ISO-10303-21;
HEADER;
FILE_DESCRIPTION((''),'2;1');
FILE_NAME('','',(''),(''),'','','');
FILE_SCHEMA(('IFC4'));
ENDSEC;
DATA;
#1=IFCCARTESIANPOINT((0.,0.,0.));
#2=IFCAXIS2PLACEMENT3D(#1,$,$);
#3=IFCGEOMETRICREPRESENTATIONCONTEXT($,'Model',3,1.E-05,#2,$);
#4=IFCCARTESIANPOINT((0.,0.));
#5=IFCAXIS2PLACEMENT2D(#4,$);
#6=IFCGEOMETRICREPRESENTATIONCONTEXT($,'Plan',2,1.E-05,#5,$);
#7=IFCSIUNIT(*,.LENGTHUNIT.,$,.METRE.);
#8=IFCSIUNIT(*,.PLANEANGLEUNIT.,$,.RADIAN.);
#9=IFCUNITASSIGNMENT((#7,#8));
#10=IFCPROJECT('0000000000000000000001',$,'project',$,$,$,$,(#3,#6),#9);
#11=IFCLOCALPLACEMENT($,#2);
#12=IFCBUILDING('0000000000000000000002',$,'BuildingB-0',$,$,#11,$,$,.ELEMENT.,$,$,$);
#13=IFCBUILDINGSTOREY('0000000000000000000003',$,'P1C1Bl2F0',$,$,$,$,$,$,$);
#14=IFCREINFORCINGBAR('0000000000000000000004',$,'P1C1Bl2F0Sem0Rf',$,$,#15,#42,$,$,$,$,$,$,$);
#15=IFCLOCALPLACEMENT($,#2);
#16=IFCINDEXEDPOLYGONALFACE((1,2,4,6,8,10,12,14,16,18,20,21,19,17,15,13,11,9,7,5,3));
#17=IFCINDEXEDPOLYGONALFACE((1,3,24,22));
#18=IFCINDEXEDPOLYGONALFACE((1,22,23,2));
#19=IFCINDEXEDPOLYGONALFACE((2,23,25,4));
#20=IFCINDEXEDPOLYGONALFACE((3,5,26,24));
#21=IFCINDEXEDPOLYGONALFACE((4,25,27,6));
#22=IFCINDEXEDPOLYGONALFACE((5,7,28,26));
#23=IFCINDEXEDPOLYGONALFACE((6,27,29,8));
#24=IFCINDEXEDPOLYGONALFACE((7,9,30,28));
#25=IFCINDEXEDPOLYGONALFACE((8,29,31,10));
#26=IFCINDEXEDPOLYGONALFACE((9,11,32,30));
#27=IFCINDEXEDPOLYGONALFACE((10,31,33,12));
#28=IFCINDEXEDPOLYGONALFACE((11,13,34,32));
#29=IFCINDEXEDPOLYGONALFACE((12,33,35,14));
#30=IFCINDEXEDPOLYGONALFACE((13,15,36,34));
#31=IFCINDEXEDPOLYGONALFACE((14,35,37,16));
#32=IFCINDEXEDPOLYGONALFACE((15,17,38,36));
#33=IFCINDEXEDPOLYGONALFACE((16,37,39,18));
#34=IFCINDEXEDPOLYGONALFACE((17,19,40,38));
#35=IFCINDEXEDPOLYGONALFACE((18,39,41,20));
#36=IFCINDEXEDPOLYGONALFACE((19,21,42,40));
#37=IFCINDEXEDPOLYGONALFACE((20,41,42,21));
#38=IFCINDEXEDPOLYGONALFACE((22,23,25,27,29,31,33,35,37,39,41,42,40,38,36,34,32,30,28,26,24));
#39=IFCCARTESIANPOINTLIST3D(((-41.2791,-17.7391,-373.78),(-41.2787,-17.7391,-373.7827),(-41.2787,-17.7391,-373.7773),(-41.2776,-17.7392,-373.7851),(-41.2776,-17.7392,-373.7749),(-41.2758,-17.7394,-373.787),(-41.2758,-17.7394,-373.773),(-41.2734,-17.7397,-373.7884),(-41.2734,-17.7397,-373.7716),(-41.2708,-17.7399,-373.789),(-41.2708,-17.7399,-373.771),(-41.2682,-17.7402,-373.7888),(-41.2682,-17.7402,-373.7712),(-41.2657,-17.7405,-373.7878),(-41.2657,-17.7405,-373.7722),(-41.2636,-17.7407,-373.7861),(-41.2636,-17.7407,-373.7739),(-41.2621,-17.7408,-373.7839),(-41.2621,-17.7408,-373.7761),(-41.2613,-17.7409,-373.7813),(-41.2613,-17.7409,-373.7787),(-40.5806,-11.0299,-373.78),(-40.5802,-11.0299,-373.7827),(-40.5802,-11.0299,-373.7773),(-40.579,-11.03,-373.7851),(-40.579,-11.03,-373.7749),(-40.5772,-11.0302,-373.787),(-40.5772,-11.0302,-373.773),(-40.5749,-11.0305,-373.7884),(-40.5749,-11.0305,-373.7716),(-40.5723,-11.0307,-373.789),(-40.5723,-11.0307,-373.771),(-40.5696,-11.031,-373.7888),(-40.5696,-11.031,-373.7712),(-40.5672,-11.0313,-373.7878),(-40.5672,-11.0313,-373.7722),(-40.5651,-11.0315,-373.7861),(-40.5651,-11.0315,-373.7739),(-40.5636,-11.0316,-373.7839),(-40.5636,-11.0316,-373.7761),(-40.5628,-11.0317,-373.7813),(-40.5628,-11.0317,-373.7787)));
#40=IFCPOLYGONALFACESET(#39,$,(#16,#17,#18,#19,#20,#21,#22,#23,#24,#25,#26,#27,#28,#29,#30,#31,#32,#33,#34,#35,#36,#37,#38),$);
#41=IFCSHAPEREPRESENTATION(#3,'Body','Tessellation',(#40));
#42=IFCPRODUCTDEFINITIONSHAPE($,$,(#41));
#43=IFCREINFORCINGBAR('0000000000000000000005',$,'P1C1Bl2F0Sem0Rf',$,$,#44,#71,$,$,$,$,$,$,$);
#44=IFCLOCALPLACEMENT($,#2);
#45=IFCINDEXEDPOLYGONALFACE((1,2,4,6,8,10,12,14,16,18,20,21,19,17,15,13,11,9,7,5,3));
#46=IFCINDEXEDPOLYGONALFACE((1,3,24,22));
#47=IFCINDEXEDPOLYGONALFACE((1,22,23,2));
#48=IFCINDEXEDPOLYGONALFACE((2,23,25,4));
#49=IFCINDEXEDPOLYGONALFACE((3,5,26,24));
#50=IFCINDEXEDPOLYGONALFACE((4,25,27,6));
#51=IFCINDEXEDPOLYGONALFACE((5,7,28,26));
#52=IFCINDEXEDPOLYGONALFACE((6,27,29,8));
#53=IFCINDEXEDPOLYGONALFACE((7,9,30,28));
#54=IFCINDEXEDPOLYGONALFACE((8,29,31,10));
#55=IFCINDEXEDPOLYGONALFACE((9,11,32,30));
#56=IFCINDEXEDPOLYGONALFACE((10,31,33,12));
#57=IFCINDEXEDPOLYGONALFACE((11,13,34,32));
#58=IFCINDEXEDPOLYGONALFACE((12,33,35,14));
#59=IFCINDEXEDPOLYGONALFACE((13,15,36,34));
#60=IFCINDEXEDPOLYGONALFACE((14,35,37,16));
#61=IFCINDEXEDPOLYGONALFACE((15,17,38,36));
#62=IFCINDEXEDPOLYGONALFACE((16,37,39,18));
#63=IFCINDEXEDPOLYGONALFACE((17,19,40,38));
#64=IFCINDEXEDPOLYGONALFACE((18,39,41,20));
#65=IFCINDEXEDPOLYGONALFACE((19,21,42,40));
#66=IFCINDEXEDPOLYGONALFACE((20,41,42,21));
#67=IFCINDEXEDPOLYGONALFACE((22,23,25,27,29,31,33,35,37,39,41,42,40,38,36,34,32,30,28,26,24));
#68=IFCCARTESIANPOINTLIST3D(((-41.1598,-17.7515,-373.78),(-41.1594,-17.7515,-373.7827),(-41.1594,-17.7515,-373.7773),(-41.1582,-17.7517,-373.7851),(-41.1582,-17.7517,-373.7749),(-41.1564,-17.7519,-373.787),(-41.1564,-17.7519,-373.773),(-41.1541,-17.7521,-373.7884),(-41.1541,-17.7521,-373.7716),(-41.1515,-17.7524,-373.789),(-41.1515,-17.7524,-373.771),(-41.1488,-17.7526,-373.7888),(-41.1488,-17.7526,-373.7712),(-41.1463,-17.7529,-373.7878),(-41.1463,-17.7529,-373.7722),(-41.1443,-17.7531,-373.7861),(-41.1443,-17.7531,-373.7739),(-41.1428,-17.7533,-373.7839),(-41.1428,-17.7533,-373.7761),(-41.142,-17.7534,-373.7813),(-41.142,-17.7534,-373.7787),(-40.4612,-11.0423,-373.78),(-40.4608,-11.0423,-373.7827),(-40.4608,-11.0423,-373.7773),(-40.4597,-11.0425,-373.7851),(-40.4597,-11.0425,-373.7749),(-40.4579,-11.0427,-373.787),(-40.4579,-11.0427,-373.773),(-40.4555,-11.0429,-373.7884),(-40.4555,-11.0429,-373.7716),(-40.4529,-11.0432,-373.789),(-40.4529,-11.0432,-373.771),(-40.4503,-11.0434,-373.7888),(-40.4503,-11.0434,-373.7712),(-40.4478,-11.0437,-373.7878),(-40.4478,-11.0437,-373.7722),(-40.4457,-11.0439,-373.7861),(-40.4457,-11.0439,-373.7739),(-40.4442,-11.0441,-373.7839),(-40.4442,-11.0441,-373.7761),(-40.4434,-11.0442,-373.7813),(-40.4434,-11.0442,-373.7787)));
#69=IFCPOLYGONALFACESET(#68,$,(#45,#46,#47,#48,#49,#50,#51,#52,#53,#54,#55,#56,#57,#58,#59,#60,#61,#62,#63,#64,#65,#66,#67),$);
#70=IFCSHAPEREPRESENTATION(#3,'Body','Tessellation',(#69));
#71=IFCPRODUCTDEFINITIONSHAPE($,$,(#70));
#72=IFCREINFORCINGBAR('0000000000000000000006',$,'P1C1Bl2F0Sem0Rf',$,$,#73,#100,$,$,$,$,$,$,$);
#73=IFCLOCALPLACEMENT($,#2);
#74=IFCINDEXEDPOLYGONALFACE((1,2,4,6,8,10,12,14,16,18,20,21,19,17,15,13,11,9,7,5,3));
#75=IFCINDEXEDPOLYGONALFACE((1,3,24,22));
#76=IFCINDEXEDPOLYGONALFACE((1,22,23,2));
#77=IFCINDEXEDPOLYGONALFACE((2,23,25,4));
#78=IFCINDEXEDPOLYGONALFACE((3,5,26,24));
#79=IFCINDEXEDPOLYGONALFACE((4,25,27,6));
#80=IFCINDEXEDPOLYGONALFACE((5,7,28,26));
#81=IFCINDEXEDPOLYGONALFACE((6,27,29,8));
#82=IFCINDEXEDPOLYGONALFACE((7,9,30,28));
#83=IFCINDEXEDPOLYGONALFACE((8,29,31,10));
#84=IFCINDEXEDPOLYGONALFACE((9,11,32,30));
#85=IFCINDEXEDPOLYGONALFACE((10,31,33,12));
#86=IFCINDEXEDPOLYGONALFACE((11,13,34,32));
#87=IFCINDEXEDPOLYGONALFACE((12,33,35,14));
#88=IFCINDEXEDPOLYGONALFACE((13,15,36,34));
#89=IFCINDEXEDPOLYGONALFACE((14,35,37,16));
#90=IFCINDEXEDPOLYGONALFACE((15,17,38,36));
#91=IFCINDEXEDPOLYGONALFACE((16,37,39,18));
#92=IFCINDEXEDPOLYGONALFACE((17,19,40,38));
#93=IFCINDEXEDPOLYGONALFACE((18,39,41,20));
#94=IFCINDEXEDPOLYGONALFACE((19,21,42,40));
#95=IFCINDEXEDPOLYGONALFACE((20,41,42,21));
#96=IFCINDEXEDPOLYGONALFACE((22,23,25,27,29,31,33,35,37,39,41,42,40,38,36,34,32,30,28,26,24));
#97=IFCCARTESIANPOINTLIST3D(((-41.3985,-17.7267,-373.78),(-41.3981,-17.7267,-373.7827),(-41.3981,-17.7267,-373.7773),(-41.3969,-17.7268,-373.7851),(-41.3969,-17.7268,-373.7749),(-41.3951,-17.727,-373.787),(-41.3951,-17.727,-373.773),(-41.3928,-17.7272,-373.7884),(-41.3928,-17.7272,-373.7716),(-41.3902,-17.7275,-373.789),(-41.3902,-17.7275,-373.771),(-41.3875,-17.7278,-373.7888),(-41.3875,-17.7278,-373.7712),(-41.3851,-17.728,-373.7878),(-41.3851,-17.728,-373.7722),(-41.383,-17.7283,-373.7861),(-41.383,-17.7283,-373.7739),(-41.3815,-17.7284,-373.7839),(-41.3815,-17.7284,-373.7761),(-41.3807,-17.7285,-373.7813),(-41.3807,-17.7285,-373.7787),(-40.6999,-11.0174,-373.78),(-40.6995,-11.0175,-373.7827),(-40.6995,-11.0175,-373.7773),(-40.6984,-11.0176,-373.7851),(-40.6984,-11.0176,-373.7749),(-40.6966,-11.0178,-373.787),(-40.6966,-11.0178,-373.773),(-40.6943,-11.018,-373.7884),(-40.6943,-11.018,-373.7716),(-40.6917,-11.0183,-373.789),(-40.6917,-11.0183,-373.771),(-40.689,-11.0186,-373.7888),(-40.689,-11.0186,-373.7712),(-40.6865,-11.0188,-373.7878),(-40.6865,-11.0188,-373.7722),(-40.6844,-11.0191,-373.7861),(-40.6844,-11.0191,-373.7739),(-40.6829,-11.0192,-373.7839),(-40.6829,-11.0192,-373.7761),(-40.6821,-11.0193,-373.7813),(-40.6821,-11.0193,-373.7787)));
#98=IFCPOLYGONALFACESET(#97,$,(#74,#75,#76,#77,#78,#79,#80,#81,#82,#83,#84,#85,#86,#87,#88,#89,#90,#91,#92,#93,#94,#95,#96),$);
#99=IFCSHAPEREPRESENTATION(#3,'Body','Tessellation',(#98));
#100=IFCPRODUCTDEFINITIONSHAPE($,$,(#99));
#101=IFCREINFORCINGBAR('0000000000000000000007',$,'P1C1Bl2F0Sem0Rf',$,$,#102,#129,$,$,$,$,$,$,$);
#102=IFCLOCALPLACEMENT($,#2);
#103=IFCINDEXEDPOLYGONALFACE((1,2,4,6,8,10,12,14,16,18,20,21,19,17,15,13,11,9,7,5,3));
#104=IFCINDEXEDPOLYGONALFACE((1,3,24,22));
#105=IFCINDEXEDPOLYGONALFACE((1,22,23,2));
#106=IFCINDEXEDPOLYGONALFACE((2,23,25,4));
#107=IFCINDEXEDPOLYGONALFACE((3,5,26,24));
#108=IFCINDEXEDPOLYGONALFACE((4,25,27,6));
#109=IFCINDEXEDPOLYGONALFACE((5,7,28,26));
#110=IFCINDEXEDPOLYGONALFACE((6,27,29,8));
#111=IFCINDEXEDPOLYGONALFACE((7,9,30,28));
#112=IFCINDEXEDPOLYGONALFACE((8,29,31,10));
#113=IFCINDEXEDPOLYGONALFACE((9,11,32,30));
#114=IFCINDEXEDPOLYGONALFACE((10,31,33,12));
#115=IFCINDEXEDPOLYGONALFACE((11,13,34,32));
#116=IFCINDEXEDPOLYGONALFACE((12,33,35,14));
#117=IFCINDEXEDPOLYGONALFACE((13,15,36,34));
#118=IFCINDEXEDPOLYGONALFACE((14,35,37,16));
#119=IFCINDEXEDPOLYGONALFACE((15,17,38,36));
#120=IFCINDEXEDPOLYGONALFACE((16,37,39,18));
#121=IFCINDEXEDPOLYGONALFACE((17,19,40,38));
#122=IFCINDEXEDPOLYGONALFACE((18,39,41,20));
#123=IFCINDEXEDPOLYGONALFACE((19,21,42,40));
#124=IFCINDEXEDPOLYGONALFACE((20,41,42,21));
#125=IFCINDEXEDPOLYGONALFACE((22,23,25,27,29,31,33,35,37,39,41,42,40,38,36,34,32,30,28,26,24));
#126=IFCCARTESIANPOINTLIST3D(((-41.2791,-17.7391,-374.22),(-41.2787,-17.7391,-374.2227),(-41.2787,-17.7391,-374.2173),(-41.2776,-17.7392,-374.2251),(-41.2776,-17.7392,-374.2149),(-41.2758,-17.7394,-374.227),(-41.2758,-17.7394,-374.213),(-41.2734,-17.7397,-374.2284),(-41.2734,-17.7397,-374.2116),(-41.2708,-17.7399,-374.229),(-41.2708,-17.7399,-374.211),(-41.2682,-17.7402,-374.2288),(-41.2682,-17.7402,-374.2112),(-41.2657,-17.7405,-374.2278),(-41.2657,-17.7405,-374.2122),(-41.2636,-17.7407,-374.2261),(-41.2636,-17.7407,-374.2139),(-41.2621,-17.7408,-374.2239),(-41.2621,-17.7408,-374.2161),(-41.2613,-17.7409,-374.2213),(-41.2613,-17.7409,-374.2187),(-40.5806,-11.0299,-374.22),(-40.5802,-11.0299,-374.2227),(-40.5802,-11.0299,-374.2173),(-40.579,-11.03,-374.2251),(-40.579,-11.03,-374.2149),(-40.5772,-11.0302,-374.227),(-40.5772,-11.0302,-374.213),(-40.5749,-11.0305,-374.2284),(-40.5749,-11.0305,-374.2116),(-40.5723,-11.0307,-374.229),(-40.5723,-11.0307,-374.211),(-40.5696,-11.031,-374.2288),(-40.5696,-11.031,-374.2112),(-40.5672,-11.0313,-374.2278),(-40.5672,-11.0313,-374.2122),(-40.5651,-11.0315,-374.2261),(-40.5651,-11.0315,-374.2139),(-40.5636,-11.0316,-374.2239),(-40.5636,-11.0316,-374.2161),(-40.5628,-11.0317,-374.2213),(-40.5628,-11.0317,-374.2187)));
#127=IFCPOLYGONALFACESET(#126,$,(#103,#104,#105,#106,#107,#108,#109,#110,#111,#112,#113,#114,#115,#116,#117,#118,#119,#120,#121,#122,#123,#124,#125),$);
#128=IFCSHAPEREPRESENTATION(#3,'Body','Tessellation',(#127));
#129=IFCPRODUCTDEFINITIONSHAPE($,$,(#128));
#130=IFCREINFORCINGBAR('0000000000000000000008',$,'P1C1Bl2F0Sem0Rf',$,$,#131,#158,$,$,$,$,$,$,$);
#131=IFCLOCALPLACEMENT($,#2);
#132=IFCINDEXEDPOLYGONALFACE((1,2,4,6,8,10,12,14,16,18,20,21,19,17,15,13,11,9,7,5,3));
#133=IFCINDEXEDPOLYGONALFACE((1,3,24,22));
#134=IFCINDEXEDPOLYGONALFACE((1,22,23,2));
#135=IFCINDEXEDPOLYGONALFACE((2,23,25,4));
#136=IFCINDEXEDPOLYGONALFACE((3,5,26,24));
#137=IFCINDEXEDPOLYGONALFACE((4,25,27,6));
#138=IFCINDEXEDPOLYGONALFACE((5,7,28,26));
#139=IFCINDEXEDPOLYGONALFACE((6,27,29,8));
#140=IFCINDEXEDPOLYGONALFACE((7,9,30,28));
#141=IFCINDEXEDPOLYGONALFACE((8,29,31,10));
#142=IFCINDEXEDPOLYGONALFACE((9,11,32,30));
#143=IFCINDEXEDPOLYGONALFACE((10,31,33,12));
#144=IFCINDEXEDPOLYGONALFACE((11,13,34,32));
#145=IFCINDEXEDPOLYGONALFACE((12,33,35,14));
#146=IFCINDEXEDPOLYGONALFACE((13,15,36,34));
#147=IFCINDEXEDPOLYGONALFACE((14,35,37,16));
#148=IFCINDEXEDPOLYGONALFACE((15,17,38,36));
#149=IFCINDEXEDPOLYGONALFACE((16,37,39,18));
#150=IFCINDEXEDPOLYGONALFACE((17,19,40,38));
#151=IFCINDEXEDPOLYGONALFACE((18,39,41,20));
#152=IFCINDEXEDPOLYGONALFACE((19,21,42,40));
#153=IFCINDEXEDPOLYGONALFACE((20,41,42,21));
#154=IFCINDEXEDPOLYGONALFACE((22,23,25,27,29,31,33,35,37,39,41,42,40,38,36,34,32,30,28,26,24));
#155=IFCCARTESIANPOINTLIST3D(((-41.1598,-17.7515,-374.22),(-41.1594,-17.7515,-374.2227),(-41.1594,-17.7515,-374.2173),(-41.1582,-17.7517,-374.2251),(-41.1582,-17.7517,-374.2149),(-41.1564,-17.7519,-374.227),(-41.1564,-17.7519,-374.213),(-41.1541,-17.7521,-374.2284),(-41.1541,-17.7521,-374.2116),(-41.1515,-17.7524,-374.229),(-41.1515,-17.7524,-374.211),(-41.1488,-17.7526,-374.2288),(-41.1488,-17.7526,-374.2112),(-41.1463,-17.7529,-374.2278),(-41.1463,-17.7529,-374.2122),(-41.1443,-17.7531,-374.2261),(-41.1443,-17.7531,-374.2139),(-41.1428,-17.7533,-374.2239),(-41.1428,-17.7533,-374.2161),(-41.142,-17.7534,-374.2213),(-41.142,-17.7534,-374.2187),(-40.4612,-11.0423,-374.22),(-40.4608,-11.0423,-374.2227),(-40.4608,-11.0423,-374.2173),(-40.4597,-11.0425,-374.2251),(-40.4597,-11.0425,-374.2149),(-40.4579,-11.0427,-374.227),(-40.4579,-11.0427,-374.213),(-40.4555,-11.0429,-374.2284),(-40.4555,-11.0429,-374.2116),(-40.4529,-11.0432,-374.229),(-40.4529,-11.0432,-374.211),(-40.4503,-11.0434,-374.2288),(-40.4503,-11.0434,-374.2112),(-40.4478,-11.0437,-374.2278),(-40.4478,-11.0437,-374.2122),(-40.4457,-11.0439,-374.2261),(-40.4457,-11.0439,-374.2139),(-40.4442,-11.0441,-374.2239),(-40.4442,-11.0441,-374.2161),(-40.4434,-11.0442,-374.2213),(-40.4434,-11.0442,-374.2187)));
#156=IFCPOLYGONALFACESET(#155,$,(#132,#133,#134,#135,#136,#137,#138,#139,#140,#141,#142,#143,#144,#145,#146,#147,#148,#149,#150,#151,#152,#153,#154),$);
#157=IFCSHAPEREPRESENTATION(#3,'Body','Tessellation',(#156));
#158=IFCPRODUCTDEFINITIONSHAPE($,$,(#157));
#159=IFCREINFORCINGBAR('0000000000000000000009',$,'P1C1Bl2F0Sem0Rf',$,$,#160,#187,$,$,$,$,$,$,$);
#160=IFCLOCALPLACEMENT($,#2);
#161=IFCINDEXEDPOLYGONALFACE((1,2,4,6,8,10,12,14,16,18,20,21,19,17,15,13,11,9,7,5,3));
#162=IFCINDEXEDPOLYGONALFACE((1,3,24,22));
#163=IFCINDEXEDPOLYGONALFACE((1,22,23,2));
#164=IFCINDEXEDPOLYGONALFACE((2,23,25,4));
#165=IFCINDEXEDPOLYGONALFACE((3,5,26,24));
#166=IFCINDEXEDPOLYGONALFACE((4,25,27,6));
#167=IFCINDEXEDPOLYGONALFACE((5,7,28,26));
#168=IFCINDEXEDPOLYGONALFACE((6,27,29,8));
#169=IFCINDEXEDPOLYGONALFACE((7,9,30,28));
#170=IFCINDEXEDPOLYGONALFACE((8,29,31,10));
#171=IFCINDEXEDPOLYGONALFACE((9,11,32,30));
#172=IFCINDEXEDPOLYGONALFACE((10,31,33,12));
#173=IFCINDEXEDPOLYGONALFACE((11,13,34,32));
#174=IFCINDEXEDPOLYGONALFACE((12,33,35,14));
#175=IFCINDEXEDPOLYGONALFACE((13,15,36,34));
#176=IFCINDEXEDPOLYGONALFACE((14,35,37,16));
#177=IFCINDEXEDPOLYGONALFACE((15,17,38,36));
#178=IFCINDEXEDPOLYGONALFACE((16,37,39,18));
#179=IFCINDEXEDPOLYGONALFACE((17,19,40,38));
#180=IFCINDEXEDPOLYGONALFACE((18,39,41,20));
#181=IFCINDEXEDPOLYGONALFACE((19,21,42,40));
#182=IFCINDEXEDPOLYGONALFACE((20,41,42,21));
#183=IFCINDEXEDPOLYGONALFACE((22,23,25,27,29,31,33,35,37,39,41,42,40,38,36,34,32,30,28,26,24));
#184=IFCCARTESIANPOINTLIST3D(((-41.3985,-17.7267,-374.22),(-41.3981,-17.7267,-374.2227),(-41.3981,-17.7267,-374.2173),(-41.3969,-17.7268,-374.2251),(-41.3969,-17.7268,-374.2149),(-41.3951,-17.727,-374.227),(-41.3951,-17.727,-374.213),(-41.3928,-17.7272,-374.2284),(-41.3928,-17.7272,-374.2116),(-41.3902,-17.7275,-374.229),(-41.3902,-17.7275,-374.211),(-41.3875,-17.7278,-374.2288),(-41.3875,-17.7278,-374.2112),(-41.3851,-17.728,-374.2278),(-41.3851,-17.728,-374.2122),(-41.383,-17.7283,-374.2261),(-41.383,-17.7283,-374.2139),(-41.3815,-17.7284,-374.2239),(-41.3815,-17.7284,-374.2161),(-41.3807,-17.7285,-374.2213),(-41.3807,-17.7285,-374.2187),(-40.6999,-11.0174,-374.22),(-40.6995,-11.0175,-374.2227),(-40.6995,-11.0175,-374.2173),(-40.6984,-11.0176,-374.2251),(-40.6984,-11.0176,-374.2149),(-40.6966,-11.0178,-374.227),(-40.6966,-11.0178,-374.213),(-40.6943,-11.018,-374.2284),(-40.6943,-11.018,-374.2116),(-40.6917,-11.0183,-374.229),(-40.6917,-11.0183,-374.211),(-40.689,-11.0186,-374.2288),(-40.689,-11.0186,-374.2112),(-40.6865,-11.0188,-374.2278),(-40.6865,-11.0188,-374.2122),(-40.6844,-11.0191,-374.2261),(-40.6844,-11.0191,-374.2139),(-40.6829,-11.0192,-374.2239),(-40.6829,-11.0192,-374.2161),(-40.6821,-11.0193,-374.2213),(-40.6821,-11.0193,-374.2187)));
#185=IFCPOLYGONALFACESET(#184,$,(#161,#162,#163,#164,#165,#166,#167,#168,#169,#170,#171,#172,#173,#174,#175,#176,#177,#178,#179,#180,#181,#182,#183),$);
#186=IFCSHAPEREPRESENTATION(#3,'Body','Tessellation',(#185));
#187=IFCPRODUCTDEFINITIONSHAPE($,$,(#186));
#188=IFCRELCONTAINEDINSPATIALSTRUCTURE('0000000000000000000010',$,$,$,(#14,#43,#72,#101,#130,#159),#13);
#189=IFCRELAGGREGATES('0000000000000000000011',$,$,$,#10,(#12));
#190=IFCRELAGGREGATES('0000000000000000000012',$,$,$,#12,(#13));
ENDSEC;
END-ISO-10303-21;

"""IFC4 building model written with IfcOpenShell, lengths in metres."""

from ifc_helpers import new_model, entity, si_unit, origin, origin_2d, place, context, project, spatial, element, save


model = new_model("IFC4")

# Units and contexts
model_context = context("Model", 3, precision=1e-05, world=origin())
plan_context = context("Plan", 2, precision=1e-05, world=origin_2d())
ifc_project = project(units=[si_unit("LENGTHUNIT", "METRE"), si_unit("PLANEANGLEUNIT", "RADIAN")], contexts=[model_context, plan_context])

# Building, storey
building_placement = place(None, origin())
building = spatial("IfcBuilding", under=ifc_project, at=building_placement, Name="BuildingB-0", CompositionType="ELEMENT")
storey = spatial("IfcBuildingStorey", under=building, Name="P1C1Bl2F0")

# Reinforcing bars
element("IfcReinforcingBar", 1, inside=storey, Name="P1C1Bl2F0Sem0Rf", context=model_context, shape_type="SweptSolid", body=[
    entity("IfcSurfaceCurveSweptAreaSolid", entity("IfcCircleProfileDef", "AREA", None, None, 0.009), None, entity("IfcPolyline", [entity("IfcCartesianPoint", [41.2702, 17.74, 373.78]), entity("IfcCartesianPoint", [40.5716, 11.0308, 373.78])]), None, None, entity("IfcPlane", entity("IfcAxis2Placement3D", entity("IfcCartesianPoint", [41.2702, 17.74, 373.78]), entity("IfcDirection", [0.0, 0.0, 1.0]), entity("IfcDirection", [1.0, 0.0, 0.0])))),
])
element("IfcReinforcingBar", 2, inside=storey, Name="P1C1Bl2F0Sem0Rf", context=model_context, shape_type="SweptSolid", body=[
    entity("IfcSurfaceCurveSweptAreaSolid", entity("IfcCircleProfileDef", "AREA", None, None, 0.009), None, entity("IfcPolyline", [entity("IfcCartesianPoint", [41.1508, 17.7524, 373.78]), entity("IfcCartesianPoint", [40.4523, 11.0432, 373.78])]), None, None, entity("IfcPlane", entity("IfcAxis2Placement3D", entity("IfcCartesianPoint", [41.1508, 17.7524, 373.78]), entity("IfcDirection", [0.0, 0.0, 1.0]), entity("IfcDirection", [1.0, 0.0, 0.0])))),
])
element("IfcReinforcingBar", 3, inside=storey, Name="P1C1Bl2F0Sem0Rf", context=model_context, shape_type="SweptSolid", body=[
    entity("IfcSurfaceCurveSweptAreaSolid", entity("IfcCircleProfileDef", "AREA", None, None, 0.009), None, entity("IfcPolyline", [entity("IfcCartesianPoint", [41.3895, 17.7276, 373.78]), entity("IfcCartesianPoint", [40.691, 11.0184, 373.78])]), None, None, entity("IfcPlane", entity("IfcAxis2Placement3D", entity("IfcCartesianPoint", [41.3895, 17.7276, 373.78]), entity("IfcDirection", [0.0, 0.0, 1.0]), entity("IfcDirection", [1.0, 0.0, 0.0])))),
])
element("IfcReinforcingBar", 4, inside=storey, Name="P1C1Bl2F0Sem0Rf", context=model_context, shape_type="SweptSolid", body=[
    entity("IfcSurfaceCurveSweptAreaSolid", entity("IfcCircleProfileDef", "AREA", None, None, 0.009), None, entity("IfcPolyline", [entity("IfcCartesianPoint", [41.2702, 17.74, 374.22]), entity("IfcCartesianPoint", [40.5716, 11.0308, 374.22])]), None, None, entity("IfcPlane", entity("IfcAxis2Placement3D", entity("IfcCartesianPoint", [41.2702, 17.74, 374.22]), entity("IfcDirection", [0.0, 0.0, 1.0]), entity("IfcDirection", [1.0, 0.0, 0.0])))),
])
element("IfcReinforcingBar", 5, inside=storey, Name="P1C1Bl2F0Sem0Rf", context=model_context, shape_type="SweptSolid", body=[
    entity("IfcSurfaceCurveSweptAreaSolid", entity("IfcCircleProfileDef", "AREA", None, None, 0.009), None, entity("IfcPolyline", [entity("IfcCartesianPoint", [41.1508, 17.7524, 374.22]), entity("IfcCartesianPoint", [40.4523, 11.0432, 374.22])]), None, None, entity("IfcPlane", entity("IfcAxis2Placement3D", entity("IfcCartesianPoint", [41.1508, 17.7524, 374.22]), entity("IfcDirection", [0.0, 0.0, 1.0]), entity("IfcDirection", [1.0, 0.0, 0.0])))),
])
element("IfcReinforcingBar", 6, inside=storey, Name="P1C1Bl2F0Sem0Rf", context=model_context, shape_type="SweptSolid", body=[
    entity("IfcSurfaceCurveSweptAreaSolid", entity("IfcCircleProfileDef", "AREA", None, None, 0.009), None, entity("IfcPolyline", [entity("IfcCartesianPoint", [41.3895, 17.7276, 374.22]), entity("IfcCartesianPoint", [40.691, 11.0184, 374.22])]), None, None, entity("IfcPlane", entity("IfcAxis2Placement3D", entity("IfcCartesianPoint", [41.3895, 17.7276, 374.22]), entity("IfcDirection", [0.0, 0.0, 1.0]), entity("IfcDirection", [1.0, 0.0, 0.0])))),
])

save(model, "model.ifc")
